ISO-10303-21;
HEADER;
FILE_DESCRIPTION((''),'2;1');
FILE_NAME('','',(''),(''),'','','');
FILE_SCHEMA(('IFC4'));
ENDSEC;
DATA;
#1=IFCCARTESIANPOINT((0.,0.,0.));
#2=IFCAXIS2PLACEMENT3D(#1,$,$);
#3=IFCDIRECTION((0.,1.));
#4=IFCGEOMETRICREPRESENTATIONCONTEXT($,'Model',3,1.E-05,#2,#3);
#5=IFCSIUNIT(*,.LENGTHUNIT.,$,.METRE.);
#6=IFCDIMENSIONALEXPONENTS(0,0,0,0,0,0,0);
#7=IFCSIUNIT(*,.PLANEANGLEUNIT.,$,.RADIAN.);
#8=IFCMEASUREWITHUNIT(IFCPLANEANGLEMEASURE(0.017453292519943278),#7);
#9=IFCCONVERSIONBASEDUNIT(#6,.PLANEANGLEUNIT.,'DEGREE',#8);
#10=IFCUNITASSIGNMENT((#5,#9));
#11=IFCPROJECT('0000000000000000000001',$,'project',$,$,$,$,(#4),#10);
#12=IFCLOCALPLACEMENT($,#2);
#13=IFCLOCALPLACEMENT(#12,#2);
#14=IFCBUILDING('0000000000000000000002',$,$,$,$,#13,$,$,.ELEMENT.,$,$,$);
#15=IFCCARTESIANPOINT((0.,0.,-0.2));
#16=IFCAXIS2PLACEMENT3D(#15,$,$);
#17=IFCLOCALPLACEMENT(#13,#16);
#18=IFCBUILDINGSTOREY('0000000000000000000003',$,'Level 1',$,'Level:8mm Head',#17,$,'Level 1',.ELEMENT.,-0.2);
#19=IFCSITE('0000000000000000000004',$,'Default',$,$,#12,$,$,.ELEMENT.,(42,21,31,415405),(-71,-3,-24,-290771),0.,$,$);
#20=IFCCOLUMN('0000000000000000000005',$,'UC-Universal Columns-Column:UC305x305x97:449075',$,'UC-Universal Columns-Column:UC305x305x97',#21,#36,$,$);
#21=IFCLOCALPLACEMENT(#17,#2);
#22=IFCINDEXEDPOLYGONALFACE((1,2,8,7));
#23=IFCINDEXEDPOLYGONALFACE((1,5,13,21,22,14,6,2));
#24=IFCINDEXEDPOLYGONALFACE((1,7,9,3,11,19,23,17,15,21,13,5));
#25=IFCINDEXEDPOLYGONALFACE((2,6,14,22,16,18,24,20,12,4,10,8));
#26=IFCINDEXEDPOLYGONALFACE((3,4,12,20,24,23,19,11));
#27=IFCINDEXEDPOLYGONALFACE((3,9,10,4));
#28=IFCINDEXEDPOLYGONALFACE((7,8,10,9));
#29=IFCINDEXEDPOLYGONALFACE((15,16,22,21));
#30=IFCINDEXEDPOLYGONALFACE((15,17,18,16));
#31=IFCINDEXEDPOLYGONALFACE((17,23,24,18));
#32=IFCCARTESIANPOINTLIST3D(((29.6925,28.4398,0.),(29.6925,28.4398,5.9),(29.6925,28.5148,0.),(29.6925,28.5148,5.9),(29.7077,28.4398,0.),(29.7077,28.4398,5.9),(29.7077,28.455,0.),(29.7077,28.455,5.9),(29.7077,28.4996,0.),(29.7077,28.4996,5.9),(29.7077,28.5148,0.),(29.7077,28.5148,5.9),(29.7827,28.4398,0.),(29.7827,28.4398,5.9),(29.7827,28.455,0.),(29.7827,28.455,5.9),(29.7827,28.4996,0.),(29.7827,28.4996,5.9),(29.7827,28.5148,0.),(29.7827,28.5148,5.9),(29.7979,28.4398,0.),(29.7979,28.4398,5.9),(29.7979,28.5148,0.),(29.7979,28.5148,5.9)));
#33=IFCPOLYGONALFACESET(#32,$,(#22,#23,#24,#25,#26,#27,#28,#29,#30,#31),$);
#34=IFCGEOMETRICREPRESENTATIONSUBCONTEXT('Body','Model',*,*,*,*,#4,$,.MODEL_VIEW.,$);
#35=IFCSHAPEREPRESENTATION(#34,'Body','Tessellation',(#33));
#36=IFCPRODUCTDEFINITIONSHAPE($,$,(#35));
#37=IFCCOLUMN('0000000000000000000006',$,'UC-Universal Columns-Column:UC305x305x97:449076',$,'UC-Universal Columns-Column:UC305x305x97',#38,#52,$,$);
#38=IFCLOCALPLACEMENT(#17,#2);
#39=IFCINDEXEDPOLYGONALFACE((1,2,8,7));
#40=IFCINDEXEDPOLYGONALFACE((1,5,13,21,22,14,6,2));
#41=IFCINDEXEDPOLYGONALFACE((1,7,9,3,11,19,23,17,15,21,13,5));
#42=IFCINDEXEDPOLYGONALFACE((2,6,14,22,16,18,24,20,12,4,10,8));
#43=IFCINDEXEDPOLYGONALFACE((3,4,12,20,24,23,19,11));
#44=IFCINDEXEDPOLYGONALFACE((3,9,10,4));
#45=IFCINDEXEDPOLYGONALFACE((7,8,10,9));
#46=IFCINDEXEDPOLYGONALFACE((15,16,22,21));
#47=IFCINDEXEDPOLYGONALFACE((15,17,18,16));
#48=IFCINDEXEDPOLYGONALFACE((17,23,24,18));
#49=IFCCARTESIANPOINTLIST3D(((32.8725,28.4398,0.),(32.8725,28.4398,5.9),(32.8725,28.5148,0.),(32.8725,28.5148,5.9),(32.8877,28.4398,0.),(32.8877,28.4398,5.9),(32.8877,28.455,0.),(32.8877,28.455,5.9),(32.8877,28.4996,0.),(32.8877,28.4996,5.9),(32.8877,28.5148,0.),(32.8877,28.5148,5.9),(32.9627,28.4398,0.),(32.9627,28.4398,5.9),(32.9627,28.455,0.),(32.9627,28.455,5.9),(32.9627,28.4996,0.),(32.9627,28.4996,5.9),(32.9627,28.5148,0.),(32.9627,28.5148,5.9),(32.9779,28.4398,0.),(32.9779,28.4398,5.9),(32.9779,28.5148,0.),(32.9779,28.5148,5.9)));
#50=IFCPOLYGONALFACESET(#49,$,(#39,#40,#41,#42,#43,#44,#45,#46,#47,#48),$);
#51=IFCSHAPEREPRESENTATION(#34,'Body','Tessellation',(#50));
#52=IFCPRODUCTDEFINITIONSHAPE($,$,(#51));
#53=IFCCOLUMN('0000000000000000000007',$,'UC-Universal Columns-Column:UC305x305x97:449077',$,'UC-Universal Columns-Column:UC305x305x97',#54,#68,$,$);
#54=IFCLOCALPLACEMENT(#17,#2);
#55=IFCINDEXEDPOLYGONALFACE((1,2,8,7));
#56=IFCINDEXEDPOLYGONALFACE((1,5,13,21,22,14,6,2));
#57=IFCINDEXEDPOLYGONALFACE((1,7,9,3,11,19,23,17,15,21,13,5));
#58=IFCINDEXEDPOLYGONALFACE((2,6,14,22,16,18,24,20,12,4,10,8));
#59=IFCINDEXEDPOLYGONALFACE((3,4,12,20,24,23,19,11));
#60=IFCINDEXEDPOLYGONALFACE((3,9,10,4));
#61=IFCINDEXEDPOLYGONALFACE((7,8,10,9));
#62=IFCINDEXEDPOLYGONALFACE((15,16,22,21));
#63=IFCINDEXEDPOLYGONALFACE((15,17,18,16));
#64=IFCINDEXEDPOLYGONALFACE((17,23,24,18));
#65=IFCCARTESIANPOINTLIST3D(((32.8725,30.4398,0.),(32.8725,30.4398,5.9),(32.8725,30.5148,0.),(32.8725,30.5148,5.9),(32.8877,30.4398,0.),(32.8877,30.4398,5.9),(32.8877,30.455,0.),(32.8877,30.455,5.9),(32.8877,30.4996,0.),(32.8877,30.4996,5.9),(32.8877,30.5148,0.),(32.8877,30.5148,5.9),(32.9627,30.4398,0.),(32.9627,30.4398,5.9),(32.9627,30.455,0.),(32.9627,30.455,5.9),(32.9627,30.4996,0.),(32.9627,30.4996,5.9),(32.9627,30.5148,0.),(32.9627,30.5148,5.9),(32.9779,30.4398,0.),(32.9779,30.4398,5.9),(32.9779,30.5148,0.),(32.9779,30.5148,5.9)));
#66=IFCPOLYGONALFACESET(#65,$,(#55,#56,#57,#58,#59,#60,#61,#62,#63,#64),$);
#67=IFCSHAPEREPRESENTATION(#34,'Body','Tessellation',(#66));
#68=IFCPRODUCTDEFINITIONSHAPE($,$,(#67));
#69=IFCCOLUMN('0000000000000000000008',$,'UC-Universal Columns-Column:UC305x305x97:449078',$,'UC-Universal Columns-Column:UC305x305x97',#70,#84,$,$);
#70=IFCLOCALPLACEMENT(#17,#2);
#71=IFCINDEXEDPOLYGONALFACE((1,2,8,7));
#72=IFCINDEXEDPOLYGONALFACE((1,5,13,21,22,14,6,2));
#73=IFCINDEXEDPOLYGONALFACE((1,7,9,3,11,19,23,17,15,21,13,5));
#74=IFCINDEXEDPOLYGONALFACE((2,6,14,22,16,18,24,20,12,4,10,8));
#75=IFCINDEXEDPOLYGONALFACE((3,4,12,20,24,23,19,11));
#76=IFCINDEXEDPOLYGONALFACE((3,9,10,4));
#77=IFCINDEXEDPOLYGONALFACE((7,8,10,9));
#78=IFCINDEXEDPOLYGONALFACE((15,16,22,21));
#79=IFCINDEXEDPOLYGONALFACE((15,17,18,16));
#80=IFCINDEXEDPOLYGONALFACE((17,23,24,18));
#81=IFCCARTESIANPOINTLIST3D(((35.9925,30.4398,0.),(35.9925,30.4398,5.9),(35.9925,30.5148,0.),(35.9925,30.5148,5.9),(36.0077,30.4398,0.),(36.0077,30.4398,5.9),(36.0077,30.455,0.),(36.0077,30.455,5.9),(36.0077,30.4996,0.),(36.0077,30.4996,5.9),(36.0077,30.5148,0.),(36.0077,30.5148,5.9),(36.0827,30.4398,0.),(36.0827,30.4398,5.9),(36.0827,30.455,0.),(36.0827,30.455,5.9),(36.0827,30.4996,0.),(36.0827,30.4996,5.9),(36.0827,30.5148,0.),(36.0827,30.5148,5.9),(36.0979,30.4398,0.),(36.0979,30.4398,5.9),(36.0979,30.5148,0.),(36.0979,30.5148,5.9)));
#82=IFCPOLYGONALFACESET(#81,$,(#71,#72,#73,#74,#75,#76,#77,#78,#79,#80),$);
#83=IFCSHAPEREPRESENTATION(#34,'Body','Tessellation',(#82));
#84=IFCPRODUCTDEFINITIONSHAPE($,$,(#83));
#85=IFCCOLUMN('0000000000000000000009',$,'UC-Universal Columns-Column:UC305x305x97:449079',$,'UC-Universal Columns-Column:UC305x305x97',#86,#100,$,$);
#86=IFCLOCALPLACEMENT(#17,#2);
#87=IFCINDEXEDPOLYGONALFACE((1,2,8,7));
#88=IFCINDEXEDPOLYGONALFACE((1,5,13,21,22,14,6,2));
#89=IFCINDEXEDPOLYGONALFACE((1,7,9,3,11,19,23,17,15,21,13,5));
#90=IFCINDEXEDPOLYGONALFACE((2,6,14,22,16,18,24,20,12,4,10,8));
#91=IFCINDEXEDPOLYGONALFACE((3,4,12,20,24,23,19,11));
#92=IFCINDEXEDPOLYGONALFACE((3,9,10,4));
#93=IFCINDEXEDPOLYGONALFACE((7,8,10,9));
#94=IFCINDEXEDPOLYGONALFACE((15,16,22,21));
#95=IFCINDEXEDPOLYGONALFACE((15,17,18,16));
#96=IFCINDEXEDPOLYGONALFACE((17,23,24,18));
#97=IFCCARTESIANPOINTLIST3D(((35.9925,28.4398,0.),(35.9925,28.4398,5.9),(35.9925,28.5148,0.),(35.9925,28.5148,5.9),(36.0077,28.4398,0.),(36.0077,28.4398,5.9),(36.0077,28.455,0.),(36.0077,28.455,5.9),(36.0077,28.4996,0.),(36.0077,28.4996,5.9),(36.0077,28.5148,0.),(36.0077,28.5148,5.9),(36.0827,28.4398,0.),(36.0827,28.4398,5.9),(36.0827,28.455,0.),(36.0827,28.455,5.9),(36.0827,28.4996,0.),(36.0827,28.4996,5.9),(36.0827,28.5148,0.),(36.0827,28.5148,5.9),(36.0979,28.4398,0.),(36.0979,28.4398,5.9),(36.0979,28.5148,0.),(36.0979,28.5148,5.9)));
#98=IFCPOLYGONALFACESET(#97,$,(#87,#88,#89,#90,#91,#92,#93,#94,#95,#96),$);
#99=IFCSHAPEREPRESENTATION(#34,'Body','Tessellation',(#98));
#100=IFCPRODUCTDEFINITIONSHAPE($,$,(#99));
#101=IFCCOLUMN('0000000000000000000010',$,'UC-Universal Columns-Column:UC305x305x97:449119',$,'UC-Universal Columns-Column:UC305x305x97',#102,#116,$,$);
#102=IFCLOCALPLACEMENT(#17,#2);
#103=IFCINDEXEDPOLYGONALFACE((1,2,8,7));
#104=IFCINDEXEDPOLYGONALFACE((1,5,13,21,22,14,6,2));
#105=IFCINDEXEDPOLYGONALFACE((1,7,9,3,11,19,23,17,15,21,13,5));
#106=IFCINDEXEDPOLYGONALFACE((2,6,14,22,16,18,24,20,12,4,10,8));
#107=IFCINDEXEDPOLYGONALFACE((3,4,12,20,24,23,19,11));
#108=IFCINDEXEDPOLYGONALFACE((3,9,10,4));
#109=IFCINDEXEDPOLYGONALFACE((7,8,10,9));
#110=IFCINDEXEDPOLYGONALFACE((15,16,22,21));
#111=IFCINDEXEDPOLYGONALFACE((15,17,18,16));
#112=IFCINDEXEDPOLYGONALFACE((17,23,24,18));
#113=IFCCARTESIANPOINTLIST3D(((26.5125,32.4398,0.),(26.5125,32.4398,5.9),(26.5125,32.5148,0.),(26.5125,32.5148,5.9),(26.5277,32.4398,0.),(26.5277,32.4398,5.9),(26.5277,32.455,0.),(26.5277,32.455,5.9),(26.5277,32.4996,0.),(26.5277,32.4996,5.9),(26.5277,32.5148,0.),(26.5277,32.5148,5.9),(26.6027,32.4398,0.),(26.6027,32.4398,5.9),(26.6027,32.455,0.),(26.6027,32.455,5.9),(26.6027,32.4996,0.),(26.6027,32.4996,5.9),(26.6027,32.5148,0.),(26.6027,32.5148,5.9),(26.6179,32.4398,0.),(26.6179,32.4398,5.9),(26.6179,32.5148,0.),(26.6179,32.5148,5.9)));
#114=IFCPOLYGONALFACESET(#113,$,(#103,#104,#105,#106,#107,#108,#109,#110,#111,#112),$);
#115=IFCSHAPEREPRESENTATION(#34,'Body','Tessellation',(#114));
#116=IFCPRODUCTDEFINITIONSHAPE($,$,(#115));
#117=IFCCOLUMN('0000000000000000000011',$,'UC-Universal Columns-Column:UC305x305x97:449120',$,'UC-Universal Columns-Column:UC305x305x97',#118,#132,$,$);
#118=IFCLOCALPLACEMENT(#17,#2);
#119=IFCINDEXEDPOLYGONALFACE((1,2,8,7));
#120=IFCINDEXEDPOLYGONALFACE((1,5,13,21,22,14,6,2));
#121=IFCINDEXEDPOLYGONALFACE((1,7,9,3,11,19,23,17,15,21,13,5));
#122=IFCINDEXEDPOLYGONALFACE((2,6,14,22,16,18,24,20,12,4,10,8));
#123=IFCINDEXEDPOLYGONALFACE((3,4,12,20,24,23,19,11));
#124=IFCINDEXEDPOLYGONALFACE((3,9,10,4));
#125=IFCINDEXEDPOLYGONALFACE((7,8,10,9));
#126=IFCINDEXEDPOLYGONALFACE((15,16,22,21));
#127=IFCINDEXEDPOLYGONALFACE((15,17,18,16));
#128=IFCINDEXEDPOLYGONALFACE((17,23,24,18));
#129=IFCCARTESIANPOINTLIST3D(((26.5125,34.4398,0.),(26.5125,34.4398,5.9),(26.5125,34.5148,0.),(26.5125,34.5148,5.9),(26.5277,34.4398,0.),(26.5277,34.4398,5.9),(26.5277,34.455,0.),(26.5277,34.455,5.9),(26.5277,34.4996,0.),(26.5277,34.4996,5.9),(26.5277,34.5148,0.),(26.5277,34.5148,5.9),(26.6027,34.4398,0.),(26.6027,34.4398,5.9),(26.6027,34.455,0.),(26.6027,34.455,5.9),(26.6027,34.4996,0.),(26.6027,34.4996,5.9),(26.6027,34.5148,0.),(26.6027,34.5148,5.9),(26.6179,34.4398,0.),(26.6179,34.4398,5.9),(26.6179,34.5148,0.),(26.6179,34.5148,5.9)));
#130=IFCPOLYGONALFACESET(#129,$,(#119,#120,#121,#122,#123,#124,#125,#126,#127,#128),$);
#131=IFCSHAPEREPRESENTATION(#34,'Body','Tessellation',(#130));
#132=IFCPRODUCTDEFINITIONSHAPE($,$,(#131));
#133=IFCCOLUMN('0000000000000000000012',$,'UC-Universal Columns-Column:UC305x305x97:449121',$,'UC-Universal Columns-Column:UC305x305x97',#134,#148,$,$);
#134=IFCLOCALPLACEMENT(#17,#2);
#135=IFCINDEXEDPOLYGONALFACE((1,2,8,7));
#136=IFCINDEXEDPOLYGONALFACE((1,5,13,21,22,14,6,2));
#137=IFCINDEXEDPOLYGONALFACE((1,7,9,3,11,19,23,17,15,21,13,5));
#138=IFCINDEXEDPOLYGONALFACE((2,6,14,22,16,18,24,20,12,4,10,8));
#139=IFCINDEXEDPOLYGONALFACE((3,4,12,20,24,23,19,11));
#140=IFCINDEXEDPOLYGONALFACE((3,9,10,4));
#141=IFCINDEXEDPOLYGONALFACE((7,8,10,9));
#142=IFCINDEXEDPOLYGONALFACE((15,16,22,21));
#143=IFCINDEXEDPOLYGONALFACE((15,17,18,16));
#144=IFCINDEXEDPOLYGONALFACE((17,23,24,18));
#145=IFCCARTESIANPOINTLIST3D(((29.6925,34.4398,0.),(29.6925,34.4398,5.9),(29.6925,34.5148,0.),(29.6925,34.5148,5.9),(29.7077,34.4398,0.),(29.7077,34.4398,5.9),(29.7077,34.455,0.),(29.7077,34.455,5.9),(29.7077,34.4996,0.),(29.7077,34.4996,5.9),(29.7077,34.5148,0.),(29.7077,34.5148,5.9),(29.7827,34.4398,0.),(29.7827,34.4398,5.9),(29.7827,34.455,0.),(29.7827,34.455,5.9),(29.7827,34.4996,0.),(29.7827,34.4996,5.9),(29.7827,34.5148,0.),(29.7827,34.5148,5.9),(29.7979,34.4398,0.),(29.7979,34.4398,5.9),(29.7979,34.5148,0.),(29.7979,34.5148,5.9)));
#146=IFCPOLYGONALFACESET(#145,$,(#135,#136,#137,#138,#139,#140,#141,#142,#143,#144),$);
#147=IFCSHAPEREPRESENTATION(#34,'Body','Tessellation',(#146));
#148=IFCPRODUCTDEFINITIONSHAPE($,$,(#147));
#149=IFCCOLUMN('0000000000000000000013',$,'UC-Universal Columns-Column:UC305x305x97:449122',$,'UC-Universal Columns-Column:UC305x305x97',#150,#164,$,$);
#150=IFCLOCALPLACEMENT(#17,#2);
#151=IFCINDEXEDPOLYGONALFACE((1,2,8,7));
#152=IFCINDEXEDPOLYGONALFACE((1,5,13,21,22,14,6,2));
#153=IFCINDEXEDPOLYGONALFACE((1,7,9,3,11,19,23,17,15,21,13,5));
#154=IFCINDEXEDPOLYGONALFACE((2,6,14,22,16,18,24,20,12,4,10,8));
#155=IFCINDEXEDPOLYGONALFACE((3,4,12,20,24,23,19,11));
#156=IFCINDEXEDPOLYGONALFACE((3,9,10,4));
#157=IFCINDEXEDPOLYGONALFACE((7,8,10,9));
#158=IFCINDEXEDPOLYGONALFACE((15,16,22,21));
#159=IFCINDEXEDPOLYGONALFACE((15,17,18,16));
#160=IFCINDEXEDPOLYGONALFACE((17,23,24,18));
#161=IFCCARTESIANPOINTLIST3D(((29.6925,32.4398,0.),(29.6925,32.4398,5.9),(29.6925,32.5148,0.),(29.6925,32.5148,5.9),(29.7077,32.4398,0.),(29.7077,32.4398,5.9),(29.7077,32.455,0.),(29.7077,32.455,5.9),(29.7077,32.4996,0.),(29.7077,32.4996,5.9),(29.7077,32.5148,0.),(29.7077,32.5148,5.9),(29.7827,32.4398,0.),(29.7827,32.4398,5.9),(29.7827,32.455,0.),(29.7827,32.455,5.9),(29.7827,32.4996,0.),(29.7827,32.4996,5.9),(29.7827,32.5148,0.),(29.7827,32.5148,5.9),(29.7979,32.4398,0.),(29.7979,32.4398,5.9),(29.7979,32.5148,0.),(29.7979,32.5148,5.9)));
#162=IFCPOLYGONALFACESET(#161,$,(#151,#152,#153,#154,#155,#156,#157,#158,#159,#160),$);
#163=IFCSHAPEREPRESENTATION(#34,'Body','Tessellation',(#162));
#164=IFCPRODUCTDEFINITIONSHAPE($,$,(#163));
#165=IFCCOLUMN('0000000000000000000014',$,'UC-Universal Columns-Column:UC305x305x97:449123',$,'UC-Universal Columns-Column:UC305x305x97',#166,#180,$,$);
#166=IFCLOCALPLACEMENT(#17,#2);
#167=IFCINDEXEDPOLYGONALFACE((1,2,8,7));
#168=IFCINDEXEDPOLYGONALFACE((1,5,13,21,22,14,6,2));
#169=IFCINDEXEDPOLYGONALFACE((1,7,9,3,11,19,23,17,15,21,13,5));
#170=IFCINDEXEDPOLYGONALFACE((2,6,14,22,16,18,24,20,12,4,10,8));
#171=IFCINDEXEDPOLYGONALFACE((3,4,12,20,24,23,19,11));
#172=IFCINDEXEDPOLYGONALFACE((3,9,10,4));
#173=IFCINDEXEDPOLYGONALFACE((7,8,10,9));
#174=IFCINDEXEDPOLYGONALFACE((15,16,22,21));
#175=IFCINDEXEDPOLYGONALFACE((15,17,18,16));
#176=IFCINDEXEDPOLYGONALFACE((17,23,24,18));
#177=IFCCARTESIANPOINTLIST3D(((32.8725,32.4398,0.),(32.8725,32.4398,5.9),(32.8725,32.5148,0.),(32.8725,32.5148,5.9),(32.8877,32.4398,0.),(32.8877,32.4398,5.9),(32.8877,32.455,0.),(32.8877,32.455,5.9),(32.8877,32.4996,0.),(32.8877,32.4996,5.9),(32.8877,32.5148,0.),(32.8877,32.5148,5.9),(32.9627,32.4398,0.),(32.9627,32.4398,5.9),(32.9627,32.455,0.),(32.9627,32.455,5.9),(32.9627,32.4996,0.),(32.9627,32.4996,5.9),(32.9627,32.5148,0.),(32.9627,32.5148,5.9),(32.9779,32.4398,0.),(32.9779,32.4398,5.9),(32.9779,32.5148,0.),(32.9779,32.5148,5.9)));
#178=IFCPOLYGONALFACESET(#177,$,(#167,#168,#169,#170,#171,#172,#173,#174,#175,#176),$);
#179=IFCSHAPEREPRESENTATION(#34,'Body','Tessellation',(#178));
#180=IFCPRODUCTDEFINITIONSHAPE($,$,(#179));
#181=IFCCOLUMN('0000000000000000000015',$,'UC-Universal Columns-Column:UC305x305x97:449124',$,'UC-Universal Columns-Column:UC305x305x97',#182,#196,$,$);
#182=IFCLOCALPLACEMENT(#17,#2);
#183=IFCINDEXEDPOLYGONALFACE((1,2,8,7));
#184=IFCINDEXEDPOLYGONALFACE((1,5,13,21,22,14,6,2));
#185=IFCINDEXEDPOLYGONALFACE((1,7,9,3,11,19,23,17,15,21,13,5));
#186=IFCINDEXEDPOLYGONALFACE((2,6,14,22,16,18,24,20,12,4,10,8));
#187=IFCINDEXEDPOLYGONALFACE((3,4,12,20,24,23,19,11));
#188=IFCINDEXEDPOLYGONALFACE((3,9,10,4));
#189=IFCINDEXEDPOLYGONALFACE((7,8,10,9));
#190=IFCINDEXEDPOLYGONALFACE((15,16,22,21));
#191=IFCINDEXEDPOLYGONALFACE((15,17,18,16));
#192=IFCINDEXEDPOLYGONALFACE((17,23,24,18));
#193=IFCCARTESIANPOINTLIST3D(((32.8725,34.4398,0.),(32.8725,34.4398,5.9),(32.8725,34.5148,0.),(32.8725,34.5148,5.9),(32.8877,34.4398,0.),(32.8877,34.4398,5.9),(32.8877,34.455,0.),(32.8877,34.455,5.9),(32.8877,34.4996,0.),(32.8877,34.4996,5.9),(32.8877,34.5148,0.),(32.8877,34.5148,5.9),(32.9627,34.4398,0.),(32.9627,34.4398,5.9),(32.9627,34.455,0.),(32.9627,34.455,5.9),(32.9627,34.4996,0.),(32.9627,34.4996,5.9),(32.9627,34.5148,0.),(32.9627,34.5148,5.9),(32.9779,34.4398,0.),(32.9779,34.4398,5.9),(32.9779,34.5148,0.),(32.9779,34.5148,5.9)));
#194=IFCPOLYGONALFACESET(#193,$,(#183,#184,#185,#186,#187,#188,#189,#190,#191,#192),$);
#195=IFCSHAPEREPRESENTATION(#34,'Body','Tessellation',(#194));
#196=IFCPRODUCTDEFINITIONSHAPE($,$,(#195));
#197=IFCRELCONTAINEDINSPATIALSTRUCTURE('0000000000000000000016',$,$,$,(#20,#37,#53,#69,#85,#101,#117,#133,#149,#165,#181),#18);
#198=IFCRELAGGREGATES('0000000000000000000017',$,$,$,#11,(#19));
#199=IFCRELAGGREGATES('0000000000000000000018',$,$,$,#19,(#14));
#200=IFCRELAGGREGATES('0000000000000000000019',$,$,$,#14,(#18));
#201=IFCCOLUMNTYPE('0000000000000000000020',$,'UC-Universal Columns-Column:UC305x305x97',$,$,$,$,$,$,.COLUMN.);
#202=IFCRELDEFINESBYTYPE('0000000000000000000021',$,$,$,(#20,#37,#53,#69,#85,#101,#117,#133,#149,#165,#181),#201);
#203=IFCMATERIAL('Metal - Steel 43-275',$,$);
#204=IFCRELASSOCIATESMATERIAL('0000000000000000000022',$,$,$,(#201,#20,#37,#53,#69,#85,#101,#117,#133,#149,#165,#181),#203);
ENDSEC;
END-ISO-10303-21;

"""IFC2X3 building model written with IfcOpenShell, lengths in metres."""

from ifc_helpers import new_model, entity, si_unit, converted_unit, direction, frame, frame_2d, origin, place, context, subcontext, project, spatial, polyline, circle_curve, parameter, trimmed, segment, composite_curve, outline, extrude, source, transform, mapped, material, type_object, type_shapes, element, save


model = new_model("IFC2X3")

# Units and contexts
model_context = context("Model", 3, precision=1e-05, world=origin(), true_north=direction((0.0, 1.0)))
body_context = subcontext(model_context, "Body", "Model", "MODEL_VIEW")
ifc_project = project(units=[si_unit("LENGTHUNIT", "METRE"), converted_unit("PLANEANGLEUNIT", "DEGREE", entity("IfcPlaneAngleMeasure", 0.017453292519943278), si_unit("PLANEANGLEUNIT", "RADIAN"), dimensions=[0, 0, 0, 0, 0, 0, 0])], contexts=[model_context])

# Site, building, storey
site_placement = place(None, origin())
site = spatial("IfcSite", under=ifc_project, at=site_placement, Name="Default", CompositionType="ELEMENT", RefLatitude=(42, 21, 31, 415405), RefLongitude=(-71, -3, -24, -290771), RefElevation=0.0)
building_placement = place(site_placement, origin())
building = spatial("IfcBuilding", under=site, at=building_placement, CompositionType="ELEMENT")
storey_placement = place(building_placement, frame((0.0, 0.0, -0.2)))
storey = spatial("IfcBuildingStorey", under=building, at=storey_placement, Name="Level 1", ObjectType="Level:8mm Head", LongName="Level 1", CompositionType="ELEMENT", Elevation=-0.2)

# Columns
ifc_material = material(Name="Metal - Steel 43-275")
column_type = type_object("IfcColumnType", Name="UC-Universal Columns-Column:UC305x305x97", PredefinedType="COLUMN", material=ifc_material)
shared_shape = source(origin(), body_context, "Body", "SweptSolid", [
    extrude(outline(composite_curve([segment(polyline([(-0.0375, -0.0375), (0.0375, -0.0375)]), True, "CONTINUOUS"), segment(polyline([(0.0375, -0.0375), (0.0527, -0.0375)]), True, "CONTINUOUS"), segment(trimmed(circle_curve(frame_2d((0.0527, -0.0223), x_axis=(-1.0, 0.0)), 0.0152), [parameter(0.0)], [parameter(90.0)], True, "PARAMETER"), False, "CONTINUOUS"), segment(polyline([(0.0375, -0.0223), (0.0375, 0.0223)]), True, "CONTINUOUS"), segment(trimmed(circle_curve(frame_2d((0.0527, 0.0223), x_axis=(-1.0, 0.0)), 0.0152), [parameter(270.0)], [parameter(0.0)], True, "PARAMETER"), False, "CONTINUOUS"), segment(polyline([(0.0527, 0.0375), (0.0375, 0.0375)]), True, "CONTINUOUS"), segment(polyline([(0.0375, 0.0375), (-0.0375, 0.0375)]), True, "CONTINUOUS"), segment(polyline([(-0.0375, 0.0375), (-0.0527, 0.0375)]), True, "CONTINUOUS"), segment(trimmed(circle_curve(frame_2d((-0.0527, 0.0223), x_axis=(-1.0, 0.0)), 0.0152), [parameter(180.0)], [parameter(270.0)], True, "PARAMETER"), False, "CONTINUOUS"), segment(polyline([(-0.0375, 0.0223), (-0.0375, -0.0223)]), True, "CONTINUOUS"), segment(trimmed(circle_curve(frame_2d((-0.0527, -0.0223), x_axis=(-1.0, 0.0)), 0.0152), [parameter(90.0)], [parameter(180.0)], True, "PARAMETER"), False, "CONTINUOUS"), segment(polyline([(-0.0527, -0.0375), (-0.0375, -0.0375)]), True, "CONTINUOUS")], self_intersect=False)), frame((0.0, 0.0, -0.2), z_axis=(0.0, 0.0, 1.0), x_axis=(-1.0, 0.0, 0.0)), (0.0, 0.0, 1.0), 5.9),
])
type_shapes(column_type, [shared_shape])
for number, where, z_axis, x_axis, name in (
    (1, (29.7452, 28.4773, 0.2), (0.0, 0.0, 1.0), (-1.0, 0.0, 0.0), "UC-Universal Columns-Column:UC305x305x97:449075"),
    (2, (32.9252, 28.4773, 0.2), (0.0, 0.0, 1.0), (-1.0, 0.0, 0.0), "UC-Universal Columns-Column:UC305x305x97:449076"),
    (3, (32.9252, 30.4773, 0.2), (0.0, 0.0, 1.0), (-1.0, 0.0, 0.0), "UC-Universal Columns-Column:UC305x305x97:449077"),
    (4, (36.0452, 30.4773, 0.2), (0.0, 0.0, 1.0), (-1.0, 0.0, 0.0), "UC-Universal Columns-Column:UC305x305x97:449078"),
    (5, (36.0452, 28.4773, 0.2), (0.0, 0.0, 1.0), (-1.0, 0.0, 0.0), "UC-Universal Columns-Column:UC305x305x97:449079"),
    (6, (26.5652, 32.4773, 0.2), (0.0, 0.0, 1.0), (-1.0, 0.0, 0.0), "UC-Universal Columns-Column:UC305x305x97:449119"),
    (7, (26.5652, 34.4773, 0.2), (0.0, 0.0, 1.0), (-1.0, 0.0, 0.0), "UC-Universal Columns-Column:UC305x305x97:449120"),
    (8, (29.7452, 34.4773, 0.2), (0.0, 0.0, 1.0), (-1.0, 0.0, 0.0), "UC-Universal Columns-Column:UC305x305x97:449121"),
    (9, (29.7452, 32.4773, 0.2), (0.0, 0.0, 1.0), (-1.0, 0.0, 0.0), "UC-Universal Columns-Column:UC305x305x97:449122"),
    (10, (32.9252, 32.4773, 0.2), (0.0, 0.0, 1.0), (-1.0, 0.0, 0.0), "UC-Universal Columns-Column:UC305x305x97:449123"),
    (11, (32.9252, 34.4773, 0.2), (0.0, 0.0, 1.0), (-1.0, 0.0, 0.0), "UC-Universal Columns-Column:UC305x305x97:449124"),
):
    element("IfcColumn", number, at=place(storey_placement, frame(where, z_axis=z_axis, x_axis=x_axis)), inside=storey, type_object=column_type, material=ifc_material, Name=name, ObjectType="UC-Universal Columns-Column:UC305x305x97", context=body_context, shape_type="MappedRepresentation", body=[
        mapped(shared_shape, transform((0.0, 0.0, 0.0), scale=1.0)),
    ])

save(model, "model.ifc")
